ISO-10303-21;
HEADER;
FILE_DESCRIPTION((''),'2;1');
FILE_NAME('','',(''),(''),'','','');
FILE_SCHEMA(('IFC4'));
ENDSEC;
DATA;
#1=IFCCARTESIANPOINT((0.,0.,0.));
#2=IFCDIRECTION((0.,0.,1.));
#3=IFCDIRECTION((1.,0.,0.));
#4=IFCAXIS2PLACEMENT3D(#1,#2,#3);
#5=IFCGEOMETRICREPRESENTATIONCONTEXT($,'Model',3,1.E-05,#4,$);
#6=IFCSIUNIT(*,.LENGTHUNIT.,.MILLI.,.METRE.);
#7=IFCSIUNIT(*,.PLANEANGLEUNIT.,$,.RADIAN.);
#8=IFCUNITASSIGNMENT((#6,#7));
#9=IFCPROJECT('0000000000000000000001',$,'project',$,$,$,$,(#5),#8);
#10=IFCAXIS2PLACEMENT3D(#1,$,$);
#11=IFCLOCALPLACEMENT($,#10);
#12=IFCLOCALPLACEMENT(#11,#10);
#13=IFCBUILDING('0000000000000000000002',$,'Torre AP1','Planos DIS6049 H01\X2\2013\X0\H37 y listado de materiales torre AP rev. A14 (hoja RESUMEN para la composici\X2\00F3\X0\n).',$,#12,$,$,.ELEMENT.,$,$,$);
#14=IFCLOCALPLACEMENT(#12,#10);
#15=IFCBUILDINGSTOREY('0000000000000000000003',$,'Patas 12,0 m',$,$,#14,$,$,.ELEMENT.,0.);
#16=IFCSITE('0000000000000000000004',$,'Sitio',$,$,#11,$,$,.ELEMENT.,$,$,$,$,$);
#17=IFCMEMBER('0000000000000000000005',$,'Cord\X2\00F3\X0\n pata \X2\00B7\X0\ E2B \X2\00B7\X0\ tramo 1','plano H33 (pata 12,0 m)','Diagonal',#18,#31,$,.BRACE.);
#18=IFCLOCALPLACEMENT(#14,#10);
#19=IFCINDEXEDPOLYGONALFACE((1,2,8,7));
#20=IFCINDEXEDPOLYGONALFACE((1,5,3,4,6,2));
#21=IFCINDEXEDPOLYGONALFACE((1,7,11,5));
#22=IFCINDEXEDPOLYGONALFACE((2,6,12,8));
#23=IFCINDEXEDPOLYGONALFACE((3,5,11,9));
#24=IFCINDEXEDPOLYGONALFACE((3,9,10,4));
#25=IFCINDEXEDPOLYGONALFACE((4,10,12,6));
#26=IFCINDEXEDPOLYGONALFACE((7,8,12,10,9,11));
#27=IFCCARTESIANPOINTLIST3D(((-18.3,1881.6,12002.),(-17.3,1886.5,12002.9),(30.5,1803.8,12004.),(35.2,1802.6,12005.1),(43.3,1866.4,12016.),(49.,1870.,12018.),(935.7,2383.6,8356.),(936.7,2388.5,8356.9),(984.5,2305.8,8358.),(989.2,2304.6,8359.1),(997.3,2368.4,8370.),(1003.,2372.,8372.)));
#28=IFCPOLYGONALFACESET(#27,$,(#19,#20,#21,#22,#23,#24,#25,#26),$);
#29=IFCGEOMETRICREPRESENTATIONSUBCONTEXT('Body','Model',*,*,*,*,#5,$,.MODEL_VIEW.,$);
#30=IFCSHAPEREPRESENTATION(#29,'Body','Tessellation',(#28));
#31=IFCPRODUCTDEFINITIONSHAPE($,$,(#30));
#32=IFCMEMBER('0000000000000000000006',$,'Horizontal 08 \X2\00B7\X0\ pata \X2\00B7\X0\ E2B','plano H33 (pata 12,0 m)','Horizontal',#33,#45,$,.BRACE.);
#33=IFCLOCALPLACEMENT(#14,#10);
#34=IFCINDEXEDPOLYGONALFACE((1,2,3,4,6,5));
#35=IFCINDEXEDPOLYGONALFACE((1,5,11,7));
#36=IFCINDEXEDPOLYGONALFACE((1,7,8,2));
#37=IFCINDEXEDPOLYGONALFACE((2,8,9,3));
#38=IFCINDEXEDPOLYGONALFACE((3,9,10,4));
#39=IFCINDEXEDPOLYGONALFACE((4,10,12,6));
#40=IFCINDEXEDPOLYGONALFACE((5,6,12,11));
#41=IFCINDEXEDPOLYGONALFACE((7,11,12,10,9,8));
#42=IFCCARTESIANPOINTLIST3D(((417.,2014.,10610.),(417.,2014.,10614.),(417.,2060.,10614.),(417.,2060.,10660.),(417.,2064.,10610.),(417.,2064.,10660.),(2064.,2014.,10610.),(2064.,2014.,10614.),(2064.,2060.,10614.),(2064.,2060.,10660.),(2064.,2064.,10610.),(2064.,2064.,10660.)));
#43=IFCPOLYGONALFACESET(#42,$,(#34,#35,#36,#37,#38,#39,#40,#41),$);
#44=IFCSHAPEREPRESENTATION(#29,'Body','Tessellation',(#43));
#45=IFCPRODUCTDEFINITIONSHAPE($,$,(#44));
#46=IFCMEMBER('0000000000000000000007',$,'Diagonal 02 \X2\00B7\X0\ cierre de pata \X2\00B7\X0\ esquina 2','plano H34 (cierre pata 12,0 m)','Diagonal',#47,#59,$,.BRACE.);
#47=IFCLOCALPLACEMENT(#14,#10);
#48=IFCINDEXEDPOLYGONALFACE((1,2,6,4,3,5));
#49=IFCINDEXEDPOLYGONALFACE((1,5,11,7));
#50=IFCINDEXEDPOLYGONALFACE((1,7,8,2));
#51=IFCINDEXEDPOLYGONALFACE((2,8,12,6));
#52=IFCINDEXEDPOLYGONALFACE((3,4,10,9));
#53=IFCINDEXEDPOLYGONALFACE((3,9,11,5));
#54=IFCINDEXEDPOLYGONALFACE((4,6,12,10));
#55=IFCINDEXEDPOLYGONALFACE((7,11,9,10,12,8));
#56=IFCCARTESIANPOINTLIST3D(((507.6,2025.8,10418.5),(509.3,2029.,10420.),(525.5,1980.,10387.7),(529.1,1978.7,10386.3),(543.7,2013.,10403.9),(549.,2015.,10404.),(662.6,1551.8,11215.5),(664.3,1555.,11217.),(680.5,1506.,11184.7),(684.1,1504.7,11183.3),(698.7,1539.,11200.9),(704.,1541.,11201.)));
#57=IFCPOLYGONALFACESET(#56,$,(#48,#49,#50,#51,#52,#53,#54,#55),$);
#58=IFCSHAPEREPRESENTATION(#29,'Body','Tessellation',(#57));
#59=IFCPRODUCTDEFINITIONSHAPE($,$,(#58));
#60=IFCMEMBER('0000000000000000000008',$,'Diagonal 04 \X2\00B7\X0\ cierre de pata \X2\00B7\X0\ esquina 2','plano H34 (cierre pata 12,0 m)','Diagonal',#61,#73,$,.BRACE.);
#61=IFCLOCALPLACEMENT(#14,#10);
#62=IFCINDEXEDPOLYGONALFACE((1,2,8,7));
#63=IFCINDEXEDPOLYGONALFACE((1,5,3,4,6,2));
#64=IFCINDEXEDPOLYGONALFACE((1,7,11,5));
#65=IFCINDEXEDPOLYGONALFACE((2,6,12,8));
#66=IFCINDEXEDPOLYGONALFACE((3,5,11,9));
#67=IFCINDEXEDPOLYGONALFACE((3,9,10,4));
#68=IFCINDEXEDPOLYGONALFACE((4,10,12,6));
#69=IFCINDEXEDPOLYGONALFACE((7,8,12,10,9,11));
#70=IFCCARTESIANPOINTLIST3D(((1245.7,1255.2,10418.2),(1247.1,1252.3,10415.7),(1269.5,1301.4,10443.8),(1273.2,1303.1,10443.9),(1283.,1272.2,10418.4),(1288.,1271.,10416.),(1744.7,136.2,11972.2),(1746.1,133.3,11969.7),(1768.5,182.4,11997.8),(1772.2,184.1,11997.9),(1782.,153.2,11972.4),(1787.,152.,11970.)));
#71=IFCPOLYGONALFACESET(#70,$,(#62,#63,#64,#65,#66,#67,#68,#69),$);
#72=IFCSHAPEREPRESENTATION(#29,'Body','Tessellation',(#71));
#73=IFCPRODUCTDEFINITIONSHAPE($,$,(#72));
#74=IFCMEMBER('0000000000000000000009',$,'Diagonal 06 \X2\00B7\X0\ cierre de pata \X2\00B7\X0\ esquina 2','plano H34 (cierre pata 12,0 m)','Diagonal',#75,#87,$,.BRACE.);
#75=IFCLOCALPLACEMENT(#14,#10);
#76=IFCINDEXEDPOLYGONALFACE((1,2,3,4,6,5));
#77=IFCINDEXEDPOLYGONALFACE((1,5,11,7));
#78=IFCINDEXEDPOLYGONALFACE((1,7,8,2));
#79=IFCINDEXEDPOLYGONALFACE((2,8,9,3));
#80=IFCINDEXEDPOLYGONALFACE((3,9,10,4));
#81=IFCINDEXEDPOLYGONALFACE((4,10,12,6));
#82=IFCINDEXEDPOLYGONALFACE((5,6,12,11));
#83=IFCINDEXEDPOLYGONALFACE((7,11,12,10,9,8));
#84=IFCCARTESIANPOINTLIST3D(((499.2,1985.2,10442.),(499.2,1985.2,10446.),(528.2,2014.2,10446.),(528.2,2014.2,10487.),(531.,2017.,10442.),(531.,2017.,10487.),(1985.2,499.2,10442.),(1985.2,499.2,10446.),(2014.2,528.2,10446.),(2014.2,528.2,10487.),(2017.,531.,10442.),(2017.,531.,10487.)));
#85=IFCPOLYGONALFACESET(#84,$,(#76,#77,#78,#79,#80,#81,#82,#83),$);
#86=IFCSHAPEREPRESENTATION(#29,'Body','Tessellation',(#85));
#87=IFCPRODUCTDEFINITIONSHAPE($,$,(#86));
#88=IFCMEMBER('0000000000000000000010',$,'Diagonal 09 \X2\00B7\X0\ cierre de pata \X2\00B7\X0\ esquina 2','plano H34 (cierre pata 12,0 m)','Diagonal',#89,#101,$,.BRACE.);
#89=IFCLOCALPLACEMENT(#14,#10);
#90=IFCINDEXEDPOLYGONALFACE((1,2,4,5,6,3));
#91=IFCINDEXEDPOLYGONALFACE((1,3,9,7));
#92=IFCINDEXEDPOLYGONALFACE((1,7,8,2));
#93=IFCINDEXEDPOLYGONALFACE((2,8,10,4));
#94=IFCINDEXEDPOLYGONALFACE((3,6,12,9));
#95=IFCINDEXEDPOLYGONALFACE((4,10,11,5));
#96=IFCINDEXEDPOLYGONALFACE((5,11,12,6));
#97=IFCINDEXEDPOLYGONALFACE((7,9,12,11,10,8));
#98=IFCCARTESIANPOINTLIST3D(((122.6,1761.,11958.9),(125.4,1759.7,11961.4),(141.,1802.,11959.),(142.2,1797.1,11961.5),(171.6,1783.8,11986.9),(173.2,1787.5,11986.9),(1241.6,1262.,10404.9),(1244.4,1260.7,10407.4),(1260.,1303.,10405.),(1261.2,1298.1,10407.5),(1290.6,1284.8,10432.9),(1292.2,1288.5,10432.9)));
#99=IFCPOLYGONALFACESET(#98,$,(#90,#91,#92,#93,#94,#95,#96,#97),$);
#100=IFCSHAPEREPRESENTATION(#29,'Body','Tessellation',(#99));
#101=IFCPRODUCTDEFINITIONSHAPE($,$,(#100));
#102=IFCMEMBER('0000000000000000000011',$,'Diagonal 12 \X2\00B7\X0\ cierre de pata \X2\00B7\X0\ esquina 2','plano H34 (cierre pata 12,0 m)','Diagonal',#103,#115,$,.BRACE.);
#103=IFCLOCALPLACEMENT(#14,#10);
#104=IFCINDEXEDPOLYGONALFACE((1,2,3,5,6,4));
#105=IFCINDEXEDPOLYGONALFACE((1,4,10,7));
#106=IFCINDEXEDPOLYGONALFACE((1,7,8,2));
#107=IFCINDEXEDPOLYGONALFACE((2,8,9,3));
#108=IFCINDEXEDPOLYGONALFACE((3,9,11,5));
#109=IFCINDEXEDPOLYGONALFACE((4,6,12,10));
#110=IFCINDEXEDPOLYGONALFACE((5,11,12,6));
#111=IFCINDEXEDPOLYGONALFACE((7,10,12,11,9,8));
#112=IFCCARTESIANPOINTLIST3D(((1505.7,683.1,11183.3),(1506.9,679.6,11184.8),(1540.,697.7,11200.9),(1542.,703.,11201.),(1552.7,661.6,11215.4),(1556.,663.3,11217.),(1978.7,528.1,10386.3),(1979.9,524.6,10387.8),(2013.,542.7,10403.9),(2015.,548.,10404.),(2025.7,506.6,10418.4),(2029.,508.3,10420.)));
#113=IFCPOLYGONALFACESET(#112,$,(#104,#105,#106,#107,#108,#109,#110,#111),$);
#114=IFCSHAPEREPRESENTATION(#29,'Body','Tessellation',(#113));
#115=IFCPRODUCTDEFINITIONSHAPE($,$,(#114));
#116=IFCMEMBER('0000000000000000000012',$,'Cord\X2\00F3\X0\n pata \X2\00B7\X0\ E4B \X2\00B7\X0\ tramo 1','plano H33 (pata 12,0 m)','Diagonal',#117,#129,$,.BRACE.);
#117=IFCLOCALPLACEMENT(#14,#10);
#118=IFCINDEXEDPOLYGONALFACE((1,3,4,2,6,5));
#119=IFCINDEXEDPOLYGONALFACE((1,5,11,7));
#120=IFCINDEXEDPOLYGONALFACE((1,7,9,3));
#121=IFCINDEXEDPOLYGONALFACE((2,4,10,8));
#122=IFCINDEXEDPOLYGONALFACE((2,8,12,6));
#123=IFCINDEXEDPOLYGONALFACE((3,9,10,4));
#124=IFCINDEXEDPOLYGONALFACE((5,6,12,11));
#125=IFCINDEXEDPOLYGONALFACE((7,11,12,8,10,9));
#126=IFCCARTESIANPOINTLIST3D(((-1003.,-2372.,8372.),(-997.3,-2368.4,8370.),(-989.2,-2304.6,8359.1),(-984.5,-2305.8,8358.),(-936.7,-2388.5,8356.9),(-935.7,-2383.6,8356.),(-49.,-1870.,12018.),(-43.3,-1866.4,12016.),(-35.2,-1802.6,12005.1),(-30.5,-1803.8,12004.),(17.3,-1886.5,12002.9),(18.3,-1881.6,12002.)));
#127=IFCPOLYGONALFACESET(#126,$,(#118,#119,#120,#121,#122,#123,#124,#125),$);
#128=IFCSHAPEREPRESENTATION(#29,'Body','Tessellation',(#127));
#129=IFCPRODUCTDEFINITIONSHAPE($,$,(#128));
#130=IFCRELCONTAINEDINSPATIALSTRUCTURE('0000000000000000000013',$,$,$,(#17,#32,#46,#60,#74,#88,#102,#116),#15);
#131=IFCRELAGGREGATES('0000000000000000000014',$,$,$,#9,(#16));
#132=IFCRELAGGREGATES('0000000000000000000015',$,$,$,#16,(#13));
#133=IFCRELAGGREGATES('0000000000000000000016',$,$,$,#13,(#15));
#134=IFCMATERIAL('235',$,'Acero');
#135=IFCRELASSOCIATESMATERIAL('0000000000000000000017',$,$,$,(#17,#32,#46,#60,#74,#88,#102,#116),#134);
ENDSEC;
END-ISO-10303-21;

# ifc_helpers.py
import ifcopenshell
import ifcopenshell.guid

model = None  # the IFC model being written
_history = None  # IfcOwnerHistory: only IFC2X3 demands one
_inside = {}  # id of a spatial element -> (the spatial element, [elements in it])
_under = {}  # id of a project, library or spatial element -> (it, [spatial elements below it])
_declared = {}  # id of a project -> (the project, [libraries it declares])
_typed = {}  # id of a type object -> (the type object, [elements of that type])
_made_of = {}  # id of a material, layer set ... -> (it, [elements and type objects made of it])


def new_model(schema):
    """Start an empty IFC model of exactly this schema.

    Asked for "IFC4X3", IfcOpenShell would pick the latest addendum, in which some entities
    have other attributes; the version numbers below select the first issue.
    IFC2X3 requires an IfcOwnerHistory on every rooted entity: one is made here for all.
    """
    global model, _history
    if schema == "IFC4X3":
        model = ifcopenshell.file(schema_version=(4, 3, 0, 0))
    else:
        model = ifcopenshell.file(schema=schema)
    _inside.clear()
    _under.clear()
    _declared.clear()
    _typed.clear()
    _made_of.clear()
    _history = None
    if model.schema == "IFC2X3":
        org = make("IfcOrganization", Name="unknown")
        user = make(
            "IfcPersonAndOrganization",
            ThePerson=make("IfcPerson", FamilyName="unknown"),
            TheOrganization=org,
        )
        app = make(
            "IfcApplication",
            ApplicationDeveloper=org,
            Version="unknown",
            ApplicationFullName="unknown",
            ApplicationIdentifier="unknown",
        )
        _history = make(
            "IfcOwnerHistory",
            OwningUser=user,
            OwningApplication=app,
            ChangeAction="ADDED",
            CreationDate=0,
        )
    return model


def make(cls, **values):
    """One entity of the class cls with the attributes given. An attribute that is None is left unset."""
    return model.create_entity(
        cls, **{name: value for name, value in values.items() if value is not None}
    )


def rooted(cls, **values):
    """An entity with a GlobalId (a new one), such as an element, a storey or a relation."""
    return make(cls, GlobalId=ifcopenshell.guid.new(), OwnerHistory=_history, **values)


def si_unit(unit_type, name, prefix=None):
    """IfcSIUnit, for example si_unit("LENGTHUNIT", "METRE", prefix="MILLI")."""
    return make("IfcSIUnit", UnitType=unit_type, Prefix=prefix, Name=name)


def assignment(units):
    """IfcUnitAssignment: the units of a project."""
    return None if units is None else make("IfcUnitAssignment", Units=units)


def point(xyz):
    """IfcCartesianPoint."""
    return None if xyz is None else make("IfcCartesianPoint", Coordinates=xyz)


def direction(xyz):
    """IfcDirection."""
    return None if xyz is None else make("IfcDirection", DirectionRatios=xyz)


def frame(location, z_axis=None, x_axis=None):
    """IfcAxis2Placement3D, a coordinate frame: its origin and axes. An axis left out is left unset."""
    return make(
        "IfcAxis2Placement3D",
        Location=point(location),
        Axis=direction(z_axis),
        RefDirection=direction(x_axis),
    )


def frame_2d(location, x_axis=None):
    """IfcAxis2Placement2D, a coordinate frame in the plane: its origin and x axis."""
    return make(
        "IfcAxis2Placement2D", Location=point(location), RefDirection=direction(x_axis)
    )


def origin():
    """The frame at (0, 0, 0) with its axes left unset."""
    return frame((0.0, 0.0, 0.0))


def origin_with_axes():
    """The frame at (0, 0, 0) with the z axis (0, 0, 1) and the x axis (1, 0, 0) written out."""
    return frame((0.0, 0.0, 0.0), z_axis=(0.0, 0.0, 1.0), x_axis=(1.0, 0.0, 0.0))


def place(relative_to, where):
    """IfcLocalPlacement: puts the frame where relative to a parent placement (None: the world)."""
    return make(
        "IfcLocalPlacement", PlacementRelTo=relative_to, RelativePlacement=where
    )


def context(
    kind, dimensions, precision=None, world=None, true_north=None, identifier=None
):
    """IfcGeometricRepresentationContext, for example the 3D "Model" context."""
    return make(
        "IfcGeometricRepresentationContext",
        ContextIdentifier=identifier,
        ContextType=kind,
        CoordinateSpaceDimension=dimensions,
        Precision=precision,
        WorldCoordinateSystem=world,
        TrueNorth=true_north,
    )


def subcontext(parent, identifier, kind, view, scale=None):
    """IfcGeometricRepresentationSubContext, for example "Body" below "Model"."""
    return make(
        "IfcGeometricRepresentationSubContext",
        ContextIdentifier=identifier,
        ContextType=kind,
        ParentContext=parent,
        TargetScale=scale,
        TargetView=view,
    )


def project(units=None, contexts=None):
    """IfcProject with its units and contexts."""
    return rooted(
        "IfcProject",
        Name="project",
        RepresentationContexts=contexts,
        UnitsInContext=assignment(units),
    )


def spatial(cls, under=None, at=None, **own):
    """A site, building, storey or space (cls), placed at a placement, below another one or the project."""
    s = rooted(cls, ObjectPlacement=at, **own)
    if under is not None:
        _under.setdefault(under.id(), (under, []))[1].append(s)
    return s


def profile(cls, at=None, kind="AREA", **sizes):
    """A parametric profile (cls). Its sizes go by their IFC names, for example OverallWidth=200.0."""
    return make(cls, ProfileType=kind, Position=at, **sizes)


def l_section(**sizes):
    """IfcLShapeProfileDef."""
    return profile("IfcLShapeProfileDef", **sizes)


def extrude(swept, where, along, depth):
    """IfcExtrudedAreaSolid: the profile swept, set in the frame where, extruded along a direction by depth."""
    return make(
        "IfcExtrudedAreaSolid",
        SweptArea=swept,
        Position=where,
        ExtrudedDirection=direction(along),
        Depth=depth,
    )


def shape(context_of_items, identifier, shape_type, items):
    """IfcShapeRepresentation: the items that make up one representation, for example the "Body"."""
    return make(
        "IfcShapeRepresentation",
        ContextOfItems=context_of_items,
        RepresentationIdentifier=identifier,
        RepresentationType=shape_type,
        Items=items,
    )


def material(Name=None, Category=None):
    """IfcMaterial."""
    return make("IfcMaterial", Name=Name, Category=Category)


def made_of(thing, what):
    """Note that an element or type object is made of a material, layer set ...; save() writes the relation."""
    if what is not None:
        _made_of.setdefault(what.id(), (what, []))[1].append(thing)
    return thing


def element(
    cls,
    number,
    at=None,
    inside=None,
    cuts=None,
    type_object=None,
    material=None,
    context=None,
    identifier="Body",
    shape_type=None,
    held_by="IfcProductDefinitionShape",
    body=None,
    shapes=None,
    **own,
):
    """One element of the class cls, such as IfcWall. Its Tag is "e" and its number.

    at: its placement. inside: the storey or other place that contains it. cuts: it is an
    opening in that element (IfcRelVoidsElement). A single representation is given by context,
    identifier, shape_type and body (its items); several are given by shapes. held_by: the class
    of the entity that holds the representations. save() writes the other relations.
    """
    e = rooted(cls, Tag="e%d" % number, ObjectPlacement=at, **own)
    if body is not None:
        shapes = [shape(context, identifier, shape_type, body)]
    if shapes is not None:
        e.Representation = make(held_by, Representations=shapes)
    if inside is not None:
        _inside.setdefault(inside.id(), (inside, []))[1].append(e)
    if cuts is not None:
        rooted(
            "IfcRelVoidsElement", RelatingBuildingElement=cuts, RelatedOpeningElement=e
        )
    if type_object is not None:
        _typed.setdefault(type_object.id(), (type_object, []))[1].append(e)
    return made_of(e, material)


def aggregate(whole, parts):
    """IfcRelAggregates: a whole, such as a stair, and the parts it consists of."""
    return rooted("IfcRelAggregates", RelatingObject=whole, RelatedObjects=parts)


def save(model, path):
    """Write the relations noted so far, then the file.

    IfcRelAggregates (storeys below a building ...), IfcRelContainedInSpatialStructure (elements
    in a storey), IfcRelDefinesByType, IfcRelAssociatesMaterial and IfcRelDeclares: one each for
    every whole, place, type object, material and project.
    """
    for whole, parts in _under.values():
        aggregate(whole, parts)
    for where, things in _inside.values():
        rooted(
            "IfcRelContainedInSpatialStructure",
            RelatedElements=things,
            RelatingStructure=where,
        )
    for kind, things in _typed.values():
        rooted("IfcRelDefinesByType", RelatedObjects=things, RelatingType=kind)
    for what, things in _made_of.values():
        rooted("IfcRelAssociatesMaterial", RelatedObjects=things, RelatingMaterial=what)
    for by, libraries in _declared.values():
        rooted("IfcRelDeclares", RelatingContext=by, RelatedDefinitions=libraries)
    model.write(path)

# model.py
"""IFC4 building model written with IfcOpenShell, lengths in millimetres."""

from ifc_helpers import new_model, si_unit, frame, frame_2d, origin, origin_with_axes, place, context, subcontext, project, spatial, l_section, extrude, material, element, save


model = new_model("IFC4")

# Units and contexts
model_context = context("Model", 3, precision=1e-05, world=origin_with_axes())
body_context = subcontext(model_context, "Body", "Model", "MODEL_VIEW")
ifc_project = project(units=[si_unit("LENGTHUNIT", "METRE", prefix="MILLI"), si_unit("PLANEANGLEUNIT", "RADIAN")], contexts=[model_context])

# Site, building, storey
site_placement = place(None, origin())
site = spatial("IfcSite", under=ifc_project, at=site_placement, Name="Sitio", CompositionType="ELEMENT")
building_placement = place(site_placement, origin())
building = spatial("IfcBuilding", under=site, at=building_placement, Name="Torre AP1", Description="Planos DIS6049 H01–H37 y listado de materiales torre AP rev. A14 (hoja RESUMEN para la composición).", CompositionType="ELEMENT")
storey_placement = place(building_placement, origin())
storey = spatial("IfcBuildingStorey", under=building, at=storey_placement, Name="Patas 12,0 m", CompositionType="ELEMENT", Elevation=0.0)

# Members
ifc_material_1 = material(Name="235", Category="Acero")
member_1_placement = place(storey_placement, frame((49.0, 1870.0, 12018.0), z_axis=(0.250919, 0.132035, -0.958961), x_axis=(-0.196926, -0.962976, -0.184114)))
element("IfcMember", 1, at=member_1_placement, inside=storey, material=ifc_material_1, Name="Cordón pata · E2B · tramo 1", Description="plano H33 (pata 12,0 m)", ObjectType="Diagonal", PredefinedType="BRACE", context=body_context, shape_type="SweptSolid", body=[
    extrude(l_section(Depth=70.0, Width=70.0, Thickness=5.0, at=frame_2d((35.0, 35.0))), None, (0.0, 0.0, 1.0), 3802.0),
])
member_2_placement = place(storey_placement, frame((2064.0, 2064.0, 10610.0), z_axis=(-1.0, 0.0, 0.0), x_axis=(0.0, -1.0, 0.0)))
element("IfcMember", 2, at=member_2_placement, inside=storey, material=ifc_material_1, Name="Horizontal 08 · pata · E2B", Description="plano H33 (pata 12,0 m)", ObjectType="Horizontal", PredefinedType="BRACE", context=body_context, shape_type="SweptSolid", body=[
    extrude(l_section(Depth=50.0, Width=50.0, Thickness=4.0, at=frame_2d((25.0, 25.0))), None, (0.0, 0.0, 1.0), 1647.0),
])
member_3_placement = place(storey_placement, frame((704.0, 1541.0, 11201.0), z_axis=(-0.164865, 0.504167, -0.847724), x_axis=(-0.442792, -0.805838, -0.393142)))
element("IfcMember", 3, at=member_3_placement, inside=storey, material=ifc_material_1, Name="Diagonal 02 · cierre de pata · esquina 2", Description="plano H34 (cierre pata 12,0 m)", ObjectType="Diagonal", PredefinedType="BRACE", context=body_context, shape_type="SweptSolid", body=[
    extrude(l_section(Depth=45.0, Width=45.0, Thickness=4.0, at=frame_2d((22.5, 22.5))), None, (0.0, 0.0, 1.0), 940.2),
])
member_4_placement = place(storey_placement, frame((1787.0, 152.0, 11970.0), z_axis=(-0.252159, 0.565463, -0.785281), x_axis=(-0.909747, -0.415107, -0.006783)))
element("IfcMember", 4, at=member_4_placement, inside=storey, material=ifc_material_1, Name="Diagonal 04 · cierre de pata · esquina 2", Description="plano H34 (cierre pata 12,0 m)", ObjectType="Diagonal", PredefinedType="BRACE", context=body_context, shape_type="SweptSolid", body=[
    extrude(l_section(Depth=45.0, Width=45.0, Thickness=4.0, at=frame_2d((22.5, 22.5))), None, (0.0, 0.0, 1.0), 1978.9),
])
member_5_placement = place(storey_placement, frame((2017.0, 531.0, 10442.0), z_axis=(-0.707107, 0.707107, 0.0), x_axis=(-0.707107, -0.707107, 0.0)))
element("IfcMember", 5, at=member_5_placement, inside=storey, material=ifc_material_1, Name="Diagonal 06 · cierre de pata · esquina 2", Description="plano H34 (cierre pata 12,0 m)", ObjectType="Diagonal", PredefinedType="BRACE", context=body_context, shape_type="SweptSolid", body=[
    extrude(l_section(Depth=45.0, Width=45.0, Thickness=4.0, at=frame_2d((22.5, 22.5))), None, (0.0, 0.0, 1.0), 2101.5),
])
member_6_placement = place(storey_placement, frame((1260.0, 1303.0, 10405.0), z_axis=(-0.565463, 0.252159, 0.785281), x_axis=(-0.409744, -0.912198, -0.002135)))
element("IfcMember", 6, at=member_6_placement, inside=storey, material=ifc_material_1, Name="Diagonal 09 · cierre de pata · esquina 2", Description="plano H34 (cierre pata 12,0 m)", ObjectType="Diagonal", PredefinedType="BRACE", context=body_context, shape_type="SweptSolid", body=[
    extrude(l_section(Depth=45.0, Width=45.0, Thickness=4.0, at=frame_2d((22.5, 22.5))), None, (0.0, 0.0, 1.0), 1978.9),
])
member_7_placement = place(storey_placement, frame((2015.0, 548.0, 10404.0), z_axis=(-0.503373, 0.164953, 0.848178), x_axis=(-0.806505, -0.441981, -0.392685)))
element("IfcMember", 7, at=member_7_placement, inside=storey, material=ifc_material_1, Name="Diagonal 12 · cierre de pata · esquina 2", Description="plano H34 (cierre pata 12,0 m)", ObjectType="Diagonal", PredefinedType="BRACE", context=body_context, shape_type="SweptSolid", body=[
    extrude(l_section(Depth=45.0, Width=45.0, Thickness=4.0, at=frame_2d((22.5, 22.5))), None, (0.0, 0.0, 1.0), 939.7),
])
member_8_placement = place(storey_placement, frame((-49.0, -1870.0, 12018.0), z_axis=(-0.250919, -0.132035, -0.958961), x_axis=(0.196926, 0.962976, -0.184114)))
element("IfcMember", 8, at=member_8_placement, inside=storey, material=ifc_material_1, Name="Cordón pata · E4B · tramo 1", Description="plano H33 (pata 12,0 m)", ObjectType="Diagonal", PredefinedType="BRACE", context=body_context, shape_type="SweptSolid", body=[
    extrude(l_section(Depth=70.0, Width=70.0, Thickness=5.0, at=frame_2d((35.0, 35.0))), None, (0.0, 0.0, 1.0), 3802.0),
])

save(model, "model.ifc")
